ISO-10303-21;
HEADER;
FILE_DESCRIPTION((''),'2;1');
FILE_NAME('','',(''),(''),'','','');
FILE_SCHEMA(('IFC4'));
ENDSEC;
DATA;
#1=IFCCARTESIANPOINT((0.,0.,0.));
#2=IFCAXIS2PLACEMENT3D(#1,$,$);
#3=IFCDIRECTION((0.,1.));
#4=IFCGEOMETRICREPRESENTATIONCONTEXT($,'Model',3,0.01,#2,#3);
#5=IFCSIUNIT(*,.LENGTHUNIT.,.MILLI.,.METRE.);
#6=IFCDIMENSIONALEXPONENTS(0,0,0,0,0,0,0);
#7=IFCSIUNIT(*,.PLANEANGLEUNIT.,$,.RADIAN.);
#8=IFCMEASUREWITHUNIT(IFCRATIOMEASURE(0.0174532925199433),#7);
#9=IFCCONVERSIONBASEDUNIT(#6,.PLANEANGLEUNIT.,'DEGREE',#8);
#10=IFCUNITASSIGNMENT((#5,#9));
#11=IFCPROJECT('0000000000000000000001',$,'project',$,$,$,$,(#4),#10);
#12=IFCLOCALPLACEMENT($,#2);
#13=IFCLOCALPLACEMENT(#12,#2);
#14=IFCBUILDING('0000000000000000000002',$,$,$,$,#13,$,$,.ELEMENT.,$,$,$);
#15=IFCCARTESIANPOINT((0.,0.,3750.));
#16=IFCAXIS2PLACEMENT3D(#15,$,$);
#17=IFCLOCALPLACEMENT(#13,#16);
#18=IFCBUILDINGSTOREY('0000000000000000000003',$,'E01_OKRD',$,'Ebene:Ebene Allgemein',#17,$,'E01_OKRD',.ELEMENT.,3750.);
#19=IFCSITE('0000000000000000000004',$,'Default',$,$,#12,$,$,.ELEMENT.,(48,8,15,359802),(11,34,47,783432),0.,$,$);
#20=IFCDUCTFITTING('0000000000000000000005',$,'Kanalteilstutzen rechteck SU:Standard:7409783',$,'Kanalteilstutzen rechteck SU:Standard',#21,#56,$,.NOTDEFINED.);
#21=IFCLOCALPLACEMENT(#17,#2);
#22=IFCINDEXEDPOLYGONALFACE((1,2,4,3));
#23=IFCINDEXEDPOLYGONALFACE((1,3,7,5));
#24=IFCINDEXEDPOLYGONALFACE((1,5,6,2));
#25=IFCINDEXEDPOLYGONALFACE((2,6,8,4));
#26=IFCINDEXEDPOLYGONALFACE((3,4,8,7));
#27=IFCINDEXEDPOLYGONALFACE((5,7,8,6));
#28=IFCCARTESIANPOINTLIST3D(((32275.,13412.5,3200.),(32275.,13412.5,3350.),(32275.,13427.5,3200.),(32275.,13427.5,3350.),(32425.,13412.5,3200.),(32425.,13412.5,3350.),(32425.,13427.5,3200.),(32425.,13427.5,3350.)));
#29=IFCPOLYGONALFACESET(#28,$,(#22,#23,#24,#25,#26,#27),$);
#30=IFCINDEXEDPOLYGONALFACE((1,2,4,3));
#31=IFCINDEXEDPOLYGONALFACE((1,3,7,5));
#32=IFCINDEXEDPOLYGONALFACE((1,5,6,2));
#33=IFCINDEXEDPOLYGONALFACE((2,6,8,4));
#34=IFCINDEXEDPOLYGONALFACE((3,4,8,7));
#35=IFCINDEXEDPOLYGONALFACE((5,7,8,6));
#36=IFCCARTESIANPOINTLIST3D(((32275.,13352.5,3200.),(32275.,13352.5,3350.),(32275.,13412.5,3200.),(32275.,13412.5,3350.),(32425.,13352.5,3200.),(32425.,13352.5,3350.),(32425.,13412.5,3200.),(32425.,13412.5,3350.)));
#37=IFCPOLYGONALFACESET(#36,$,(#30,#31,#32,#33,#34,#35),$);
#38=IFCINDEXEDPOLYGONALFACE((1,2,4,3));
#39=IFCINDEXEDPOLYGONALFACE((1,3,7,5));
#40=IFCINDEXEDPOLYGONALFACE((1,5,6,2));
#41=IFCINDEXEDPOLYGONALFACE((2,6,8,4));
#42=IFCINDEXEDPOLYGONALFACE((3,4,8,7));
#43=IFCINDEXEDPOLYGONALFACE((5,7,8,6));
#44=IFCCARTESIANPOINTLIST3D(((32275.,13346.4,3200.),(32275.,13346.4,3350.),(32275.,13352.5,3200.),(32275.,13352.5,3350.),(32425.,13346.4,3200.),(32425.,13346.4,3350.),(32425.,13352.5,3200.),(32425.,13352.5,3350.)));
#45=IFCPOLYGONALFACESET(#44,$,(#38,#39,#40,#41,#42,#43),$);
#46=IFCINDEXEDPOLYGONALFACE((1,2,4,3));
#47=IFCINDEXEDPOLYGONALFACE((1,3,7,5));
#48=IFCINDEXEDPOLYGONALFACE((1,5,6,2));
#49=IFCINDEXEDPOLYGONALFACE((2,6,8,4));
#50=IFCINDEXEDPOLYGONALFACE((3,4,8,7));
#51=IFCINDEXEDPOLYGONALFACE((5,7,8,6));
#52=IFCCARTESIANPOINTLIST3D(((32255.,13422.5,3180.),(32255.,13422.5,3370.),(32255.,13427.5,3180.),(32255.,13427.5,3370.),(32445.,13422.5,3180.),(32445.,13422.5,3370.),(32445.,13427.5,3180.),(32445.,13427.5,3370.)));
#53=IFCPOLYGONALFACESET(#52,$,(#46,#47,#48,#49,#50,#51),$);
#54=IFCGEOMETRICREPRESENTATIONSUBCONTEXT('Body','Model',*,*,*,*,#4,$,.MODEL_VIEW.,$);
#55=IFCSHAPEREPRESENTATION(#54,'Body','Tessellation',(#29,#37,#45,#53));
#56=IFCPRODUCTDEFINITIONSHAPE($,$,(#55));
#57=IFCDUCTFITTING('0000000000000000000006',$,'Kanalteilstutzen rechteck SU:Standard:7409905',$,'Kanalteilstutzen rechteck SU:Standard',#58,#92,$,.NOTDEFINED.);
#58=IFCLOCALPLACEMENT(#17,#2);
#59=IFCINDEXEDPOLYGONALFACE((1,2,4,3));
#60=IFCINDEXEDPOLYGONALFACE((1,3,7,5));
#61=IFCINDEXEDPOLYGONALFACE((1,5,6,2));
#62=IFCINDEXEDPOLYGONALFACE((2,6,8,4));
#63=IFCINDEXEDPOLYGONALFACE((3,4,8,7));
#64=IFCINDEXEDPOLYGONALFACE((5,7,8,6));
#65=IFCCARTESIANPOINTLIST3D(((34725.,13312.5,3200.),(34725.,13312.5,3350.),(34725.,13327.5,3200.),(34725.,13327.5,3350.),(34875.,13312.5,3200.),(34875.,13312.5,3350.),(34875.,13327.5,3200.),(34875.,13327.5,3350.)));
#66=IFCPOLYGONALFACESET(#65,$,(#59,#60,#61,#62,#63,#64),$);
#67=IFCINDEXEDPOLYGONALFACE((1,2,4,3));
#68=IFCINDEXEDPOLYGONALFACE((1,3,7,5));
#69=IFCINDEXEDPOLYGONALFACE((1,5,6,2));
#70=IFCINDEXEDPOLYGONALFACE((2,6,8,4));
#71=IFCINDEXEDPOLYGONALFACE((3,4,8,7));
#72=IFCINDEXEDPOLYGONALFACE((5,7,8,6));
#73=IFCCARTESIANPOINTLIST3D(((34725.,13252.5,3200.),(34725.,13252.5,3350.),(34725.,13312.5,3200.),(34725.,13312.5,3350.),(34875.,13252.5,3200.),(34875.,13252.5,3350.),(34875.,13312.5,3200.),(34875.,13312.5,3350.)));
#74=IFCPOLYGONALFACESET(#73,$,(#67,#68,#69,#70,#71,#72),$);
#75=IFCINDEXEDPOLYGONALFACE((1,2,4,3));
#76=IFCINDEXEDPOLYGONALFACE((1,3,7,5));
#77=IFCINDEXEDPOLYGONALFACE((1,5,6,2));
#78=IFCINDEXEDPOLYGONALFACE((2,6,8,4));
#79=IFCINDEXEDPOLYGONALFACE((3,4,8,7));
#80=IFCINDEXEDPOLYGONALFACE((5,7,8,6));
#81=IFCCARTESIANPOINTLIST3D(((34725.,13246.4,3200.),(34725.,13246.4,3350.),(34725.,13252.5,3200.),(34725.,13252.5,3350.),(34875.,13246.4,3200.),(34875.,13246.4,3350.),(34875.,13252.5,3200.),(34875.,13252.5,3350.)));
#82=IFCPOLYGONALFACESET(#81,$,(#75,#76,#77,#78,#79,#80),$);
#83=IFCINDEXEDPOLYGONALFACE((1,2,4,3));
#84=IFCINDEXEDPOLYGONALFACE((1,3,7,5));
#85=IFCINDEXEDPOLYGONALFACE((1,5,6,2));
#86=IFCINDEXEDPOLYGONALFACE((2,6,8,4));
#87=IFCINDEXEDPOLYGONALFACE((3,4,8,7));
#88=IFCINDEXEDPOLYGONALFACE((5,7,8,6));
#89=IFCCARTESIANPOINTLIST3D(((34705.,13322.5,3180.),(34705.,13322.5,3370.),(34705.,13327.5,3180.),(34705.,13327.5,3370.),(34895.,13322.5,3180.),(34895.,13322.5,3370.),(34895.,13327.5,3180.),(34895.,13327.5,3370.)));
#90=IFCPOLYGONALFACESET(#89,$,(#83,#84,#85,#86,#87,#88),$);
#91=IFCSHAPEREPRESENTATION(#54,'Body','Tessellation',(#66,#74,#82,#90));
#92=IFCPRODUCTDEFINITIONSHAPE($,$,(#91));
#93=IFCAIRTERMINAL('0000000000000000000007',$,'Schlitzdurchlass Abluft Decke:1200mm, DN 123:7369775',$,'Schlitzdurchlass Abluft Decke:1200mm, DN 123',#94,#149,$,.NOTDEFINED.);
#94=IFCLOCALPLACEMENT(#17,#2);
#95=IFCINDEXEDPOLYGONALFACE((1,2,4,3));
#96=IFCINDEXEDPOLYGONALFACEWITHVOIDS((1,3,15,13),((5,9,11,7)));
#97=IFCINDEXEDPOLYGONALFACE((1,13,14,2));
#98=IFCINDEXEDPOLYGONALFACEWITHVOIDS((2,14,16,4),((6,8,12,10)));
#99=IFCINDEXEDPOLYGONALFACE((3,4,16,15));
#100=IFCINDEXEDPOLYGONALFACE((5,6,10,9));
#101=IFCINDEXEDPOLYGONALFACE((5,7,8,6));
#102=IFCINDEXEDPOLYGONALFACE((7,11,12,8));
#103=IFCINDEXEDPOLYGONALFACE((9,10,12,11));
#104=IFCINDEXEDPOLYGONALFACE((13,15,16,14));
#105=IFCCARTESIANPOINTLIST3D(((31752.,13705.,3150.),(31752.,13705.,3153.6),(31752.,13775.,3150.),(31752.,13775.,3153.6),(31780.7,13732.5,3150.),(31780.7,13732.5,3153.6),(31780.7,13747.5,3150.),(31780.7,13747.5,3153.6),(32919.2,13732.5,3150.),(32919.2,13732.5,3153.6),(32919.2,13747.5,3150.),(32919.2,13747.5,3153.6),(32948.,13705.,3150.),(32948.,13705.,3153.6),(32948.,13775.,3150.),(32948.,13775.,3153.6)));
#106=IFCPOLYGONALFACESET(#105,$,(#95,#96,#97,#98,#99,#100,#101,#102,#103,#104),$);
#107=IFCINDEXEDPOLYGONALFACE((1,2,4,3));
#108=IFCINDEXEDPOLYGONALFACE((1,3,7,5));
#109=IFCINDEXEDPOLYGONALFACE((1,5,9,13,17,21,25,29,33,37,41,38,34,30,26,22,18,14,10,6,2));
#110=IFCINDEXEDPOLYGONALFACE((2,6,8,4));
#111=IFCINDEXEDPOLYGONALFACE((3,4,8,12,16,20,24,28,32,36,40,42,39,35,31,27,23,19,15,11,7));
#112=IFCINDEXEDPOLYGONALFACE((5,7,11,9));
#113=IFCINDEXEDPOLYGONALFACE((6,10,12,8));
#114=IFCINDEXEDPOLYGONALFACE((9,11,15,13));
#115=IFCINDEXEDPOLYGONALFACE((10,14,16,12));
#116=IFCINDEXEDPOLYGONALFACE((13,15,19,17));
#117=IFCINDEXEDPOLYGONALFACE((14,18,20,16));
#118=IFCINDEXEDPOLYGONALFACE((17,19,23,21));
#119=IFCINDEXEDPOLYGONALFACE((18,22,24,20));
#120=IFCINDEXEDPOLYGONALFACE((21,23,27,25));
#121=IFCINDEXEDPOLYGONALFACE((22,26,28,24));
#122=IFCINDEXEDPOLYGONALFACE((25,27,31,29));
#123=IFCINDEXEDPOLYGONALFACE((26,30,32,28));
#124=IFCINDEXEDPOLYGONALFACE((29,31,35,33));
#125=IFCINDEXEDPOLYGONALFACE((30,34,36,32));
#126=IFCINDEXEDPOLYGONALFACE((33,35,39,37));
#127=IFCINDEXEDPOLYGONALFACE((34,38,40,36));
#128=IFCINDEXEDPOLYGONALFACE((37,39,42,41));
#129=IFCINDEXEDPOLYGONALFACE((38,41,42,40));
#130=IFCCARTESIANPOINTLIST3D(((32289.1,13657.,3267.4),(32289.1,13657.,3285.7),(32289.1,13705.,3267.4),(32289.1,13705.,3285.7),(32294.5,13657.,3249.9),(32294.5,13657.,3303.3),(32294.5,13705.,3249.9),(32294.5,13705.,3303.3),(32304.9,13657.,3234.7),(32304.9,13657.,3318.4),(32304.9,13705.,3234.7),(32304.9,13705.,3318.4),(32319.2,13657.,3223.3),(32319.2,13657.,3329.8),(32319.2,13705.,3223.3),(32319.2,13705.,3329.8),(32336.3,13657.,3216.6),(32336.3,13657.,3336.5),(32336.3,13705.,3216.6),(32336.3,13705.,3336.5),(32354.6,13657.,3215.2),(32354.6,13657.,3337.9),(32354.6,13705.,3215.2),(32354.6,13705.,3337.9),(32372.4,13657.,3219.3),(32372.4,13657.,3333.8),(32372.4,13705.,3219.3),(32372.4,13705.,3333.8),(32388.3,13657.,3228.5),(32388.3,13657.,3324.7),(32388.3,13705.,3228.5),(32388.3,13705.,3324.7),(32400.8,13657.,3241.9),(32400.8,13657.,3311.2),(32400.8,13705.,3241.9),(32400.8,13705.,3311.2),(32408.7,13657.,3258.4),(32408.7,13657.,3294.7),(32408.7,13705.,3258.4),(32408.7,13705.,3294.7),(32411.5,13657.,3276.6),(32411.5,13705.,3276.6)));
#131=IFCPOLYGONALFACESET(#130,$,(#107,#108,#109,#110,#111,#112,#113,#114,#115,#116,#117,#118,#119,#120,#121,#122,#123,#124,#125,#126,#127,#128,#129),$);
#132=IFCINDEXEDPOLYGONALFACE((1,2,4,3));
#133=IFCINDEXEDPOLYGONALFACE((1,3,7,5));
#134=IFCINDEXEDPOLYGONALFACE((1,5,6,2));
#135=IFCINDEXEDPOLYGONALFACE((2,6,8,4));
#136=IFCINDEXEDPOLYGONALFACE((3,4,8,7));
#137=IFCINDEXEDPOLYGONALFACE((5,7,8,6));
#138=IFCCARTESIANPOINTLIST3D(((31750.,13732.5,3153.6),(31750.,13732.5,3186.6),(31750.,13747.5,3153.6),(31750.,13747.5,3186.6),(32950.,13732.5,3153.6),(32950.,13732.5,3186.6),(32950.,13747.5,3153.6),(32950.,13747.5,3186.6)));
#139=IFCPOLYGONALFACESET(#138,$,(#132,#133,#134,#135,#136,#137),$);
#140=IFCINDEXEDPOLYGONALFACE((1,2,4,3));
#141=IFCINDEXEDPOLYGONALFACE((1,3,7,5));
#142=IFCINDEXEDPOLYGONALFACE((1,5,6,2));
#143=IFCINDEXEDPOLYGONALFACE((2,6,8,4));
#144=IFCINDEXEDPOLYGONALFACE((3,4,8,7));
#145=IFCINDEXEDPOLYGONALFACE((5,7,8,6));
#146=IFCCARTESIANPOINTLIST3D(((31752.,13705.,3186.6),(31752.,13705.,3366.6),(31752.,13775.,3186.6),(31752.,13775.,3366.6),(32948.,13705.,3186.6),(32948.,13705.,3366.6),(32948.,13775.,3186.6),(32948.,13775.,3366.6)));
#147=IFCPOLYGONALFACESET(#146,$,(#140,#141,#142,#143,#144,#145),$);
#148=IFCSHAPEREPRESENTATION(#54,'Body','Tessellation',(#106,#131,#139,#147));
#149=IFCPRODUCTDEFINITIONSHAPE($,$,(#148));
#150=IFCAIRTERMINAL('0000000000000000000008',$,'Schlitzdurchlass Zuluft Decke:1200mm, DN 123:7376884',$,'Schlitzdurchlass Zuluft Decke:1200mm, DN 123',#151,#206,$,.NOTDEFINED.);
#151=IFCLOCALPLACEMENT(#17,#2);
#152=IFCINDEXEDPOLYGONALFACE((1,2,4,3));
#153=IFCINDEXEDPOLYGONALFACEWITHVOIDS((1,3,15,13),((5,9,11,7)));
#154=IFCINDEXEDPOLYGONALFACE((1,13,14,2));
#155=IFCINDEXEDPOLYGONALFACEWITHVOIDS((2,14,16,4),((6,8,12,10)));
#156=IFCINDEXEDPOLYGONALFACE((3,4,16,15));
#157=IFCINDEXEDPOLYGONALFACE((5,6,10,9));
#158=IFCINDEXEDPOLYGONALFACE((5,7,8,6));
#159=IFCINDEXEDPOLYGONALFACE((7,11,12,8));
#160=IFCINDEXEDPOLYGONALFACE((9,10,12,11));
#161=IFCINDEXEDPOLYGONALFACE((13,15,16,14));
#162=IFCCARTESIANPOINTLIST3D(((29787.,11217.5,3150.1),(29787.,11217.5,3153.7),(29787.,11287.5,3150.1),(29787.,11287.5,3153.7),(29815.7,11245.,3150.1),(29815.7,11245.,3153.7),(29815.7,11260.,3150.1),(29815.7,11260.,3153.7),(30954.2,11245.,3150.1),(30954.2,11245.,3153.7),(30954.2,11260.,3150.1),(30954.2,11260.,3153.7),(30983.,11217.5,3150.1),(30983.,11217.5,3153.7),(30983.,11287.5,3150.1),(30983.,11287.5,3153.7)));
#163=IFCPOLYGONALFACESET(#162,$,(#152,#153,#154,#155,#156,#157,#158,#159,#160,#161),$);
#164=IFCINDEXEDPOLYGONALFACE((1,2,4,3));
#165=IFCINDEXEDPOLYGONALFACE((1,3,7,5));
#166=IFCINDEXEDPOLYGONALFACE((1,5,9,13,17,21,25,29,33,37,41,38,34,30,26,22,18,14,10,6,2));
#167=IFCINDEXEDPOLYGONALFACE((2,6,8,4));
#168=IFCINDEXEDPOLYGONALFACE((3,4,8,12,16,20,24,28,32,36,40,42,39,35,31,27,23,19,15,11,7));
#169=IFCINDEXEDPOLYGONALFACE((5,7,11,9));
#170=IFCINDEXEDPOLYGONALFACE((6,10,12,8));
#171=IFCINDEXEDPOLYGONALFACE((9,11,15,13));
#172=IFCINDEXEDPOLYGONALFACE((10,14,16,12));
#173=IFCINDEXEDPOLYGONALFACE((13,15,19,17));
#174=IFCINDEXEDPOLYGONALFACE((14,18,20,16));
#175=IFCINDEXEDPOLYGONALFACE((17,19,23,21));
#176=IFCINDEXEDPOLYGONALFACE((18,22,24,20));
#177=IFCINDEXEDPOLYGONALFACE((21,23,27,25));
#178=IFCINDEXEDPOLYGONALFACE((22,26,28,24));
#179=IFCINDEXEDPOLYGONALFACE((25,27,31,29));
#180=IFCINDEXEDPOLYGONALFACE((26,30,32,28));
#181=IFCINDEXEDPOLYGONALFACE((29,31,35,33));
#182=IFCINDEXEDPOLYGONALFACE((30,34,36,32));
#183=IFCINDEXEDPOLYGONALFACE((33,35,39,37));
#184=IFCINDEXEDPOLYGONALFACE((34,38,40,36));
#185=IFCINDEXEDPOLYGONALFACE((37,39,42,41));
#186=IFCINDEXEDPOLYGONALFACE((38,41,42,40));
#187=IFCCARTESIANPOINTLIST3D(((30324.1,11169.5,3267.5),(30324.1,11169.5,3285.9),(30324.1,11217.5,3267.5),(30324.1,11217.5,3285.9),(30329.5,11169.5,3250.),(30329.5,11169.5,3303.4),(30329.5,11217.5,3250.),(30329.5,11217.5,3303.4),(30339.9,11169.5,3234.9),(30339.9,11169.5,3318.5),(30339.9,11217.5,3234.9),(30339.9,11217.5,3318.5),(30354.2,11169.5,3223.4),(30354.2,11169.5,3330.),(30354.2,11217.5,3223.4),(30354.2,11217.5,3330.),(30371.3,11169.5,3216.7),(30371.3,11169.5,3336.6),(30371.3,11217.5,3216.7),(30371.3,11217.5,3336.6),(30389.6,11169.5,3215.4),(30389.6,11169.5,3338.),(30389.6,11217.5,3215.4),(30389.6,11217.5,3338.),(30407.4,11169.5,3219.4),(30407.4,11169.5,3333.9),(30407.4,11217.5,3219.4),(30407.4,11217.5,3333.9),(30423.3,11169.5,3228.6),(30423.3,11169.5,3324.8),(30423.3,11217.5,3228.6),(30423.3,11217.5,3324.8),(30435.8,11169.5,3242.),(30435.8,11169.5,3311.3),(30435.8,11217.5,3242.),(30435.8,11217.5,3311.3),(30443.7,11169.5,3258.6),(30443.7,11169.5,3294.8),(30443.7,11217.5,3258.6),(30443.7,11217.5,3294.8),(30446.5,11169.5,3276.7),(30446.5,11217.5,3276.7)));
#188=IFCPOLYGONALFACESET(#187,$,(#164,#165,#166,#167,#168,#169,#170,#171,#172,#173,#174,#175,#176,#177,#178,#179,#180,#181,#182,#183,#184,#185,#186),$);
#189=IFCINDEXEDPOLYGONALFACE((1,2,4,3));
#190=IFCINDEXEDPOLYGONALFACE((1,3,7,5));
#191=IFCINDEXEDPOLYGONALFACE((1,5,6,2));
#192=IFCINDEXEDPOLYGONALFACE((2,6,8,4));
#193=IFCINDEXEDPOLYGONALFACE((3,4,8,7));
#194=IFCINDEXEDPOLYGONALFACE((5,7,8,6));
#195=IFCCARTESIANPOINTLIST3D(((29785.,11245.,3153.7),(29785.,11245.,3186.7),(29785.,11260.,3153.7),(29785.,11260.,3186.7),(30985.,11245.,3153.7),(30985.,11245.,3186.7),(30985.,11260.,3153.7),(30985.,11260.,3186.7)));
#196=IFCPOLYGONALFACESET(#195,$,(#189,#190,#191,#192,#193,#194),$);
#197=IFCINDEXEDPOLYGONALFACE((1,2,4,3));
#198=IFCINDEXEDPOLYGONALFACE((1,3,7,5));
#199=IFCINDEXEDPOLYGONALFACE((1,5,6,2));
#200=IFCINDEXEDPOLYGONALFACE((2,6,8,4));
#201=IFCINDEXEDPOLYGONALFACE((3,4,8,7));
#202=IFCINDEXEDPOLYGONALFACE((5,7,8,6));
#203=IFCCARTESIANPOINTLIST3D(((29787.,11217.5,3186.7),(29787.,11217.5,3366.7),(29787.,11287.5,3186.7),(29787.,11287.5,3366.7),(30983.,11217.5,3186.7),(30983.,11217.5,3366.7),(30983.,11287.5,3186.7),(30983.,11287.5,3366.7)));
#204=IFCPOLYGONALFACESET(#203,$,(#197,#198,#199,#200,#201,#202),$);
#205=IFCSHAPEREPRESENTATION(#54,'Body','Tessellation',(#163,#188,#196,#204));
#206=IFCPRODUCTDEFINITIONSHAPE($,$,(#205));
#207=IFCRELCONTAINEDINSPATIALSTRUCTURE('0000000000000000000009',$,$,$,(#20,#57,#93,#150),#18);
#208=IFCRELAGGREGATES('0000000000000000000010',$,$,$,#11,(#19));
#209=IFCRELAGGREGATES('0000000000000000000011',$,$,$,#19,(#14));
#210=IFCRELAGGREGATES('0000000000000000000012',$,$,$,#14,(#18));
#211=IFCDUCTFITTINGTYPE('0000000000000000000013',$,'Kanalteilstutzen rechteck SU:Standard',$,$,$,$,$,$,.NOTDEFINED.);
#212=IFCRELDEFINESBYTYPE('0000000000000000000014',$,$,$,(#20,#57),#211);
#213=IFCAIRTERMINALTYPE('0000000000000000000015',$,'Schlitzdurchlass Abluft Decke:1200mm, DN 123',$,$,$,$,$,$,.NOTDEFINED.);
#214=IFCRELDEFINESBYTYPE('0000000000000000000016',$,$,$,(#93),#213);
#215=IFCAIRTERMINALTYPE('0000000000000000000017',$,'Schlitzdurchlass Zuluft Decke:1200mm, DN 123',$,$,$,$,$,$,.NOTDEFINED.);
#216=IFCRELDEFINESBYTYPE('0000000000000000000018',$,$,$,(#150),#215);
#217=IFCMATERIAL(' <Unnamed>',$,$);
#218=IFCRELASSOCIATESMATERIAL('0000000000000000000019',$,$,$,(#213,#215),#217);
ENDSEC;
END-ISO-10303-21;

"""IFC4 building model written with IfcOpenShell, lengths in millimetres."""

from ifc_helpers import new_model, entity, si_unit, converted_unit, direction, frame, frame_2d, origin, origin_2d_with_axis, place, context, subcontext, project, spatial, polyline, rectangle, circle, outline, extrude, source, transform, mapped, material, type_object, type_shapes, element, save


model = new_model("IFC4")

# Units and contexts
model_context = context("Model", 3, precision=0.01, world=origin(), true_north=direction((0.0, 1.0)))
body_context = subcontext(model_context, "Body", "Model", "MODEL_VIEW")
ifc_project = project(units=[si_unit("LENGTHUNIT", "METRE", prefix="MILLI"), converted_unit("PLANEANGLEUNIT", "DEGREE", entity("IfcRatioMeasure", 0.0174532925199433), si_unit("PLANEANGLEUNIT", "RADIAN"), dimensions=[0, 0, 0, 0, 0, 0, 0])], contexts=[model_context])

# Site, building, storey
site_placement = place(None, origin())
site = spatial("IfcSite", under=ifc_project, at=site_placement, Name="Default", CompositionType="ELEMENT", RefLatitude=(48, 8, 15, 359802), RefLongitude=(11, 34, 47, 783432), RefElevation=0.0)
building_placement = place(site_placement, origin())
building = spatial("IfcBuilding", under=site, at=building_placement, CompositionType="ELEMENT")
storey_placement = place(building_placement, frame((0.0, 0.0, 3750.0)))
storey = spatial("IfcBuildingStorey", under=building, at=storey_placement, Name="E01_OKRD", ObjectType="Ebene:Ebene Allgemein", LongName="E01_OKRD", CompositionType="ELEMENT", Elevation=3750.0)

# Duct fittings
duct_fitting_type_1 = type_object("IfcDuctFittingType", Name="Kanalteilstutzen rechteck SU:Standard", PredefinedType="NOTDEFINED")
shared_shape_1 = source(origin(), body_context, "Body", "SweptSolid", [
    extrude(rectangle(XDim=15.0, YDim=150.0, at=frame_2d((0.0, 0.0), x_axis=(1.0, 0.0))), frame((67.5, 0.0, -75.0)), (0.0, 0.0, 1.0), 150.0),
    extrude(rectangle(XDim=60.0, YDim=150.0, at=frame_2d((0.0, 0.0), x_axis=(1.0, 0.0))), frame((30.0, 0.0, -75.0)), (0.0, 0.0, 1.0), 150.0),
    extrude(rectangle(XDim=6.1, YDim=150.0, at=frame_2d((0.0, 0.0), x_axis=(1.0, 0.0))), frame((-3.0, 0.0, -75.0)), (0.0, 0.0, 1.0), 150.0),
    extrude(rectangle(XDim=5.0, YDim=190.0, at=origin_2d_with_axis()), frame((72.5, 0.0, -95.0)), (0.0, 0.0, 1.0), 190.0),
])
type_shapes(duct_fitting_type_1, [shared_shape_1])
for number, where, z_axis, x_axis, name in (
    (1, (32350.0, 13352.5, 3275.0), (0.0, 0.0, -1.0), (0.0, 1.0, 0.0), "Kanalteilstutzen rechteck SU:Standard:7409783"),
    (2, (34800.0, 13252.5, 3275.0), (0.0, 0.0, -1.0), (0.0, 1.0, 0.0), "Kanalteilstutzen rechteck SU:Standard:7409905"),
):
    element("IfcDuctFitting", number, at=place(storey_placement, frame(where, z_axis=z_axis, x_axis=x_axis)), inside=storey, type_object=duct_fitting_type_1, Name=name, ObjectType="Kanalteilstutzen rechteck SU:Standard", PredefinedType="NOTDEFINED", context=body_context, shape_type="MappedRepresentation", body=[
        mapped(shared_shape_1, transform((0.0, 0.0, 0.0), scale=1.0)),
    ])

# Air terminals
ifc_material_1 = material(Name=" <Unnamed>")
air_terminal_type_1 = type_object("IfcAirTerminalType", Name="Schlitzdurchlass Abluft Decke:1200mm, DN 123", PredefinedType="NOTDEFINED", material=ifc_material_1)
shared_shape_2 = source(origin(), body_context, "Body", "SweptSolid", [
    extrude(outline(polyline([(-598.0, -35.0), (598.0, -35.0), (598.0, 35.0), (-598.0, 35.0), (-598.0, -35.0)]), holes=[polyline([(-569.2, -7.5), (-569.2, 7.5), (569.2, 7.5), (569.2, -7.5), (-569.2, -7.5)])]), frame((0.0, 0.0, 0.0), z_axis=(0.0, 0.0, 1.0), x_axis=(-1.0, 0.0, 0.0)), (0.0, 0.0, 1.0), 3.6),
    extrude(circle(Radius=61.5, at=frame_2d((0.0, 0.0), x_axis=(1.0, 0.0))), frame((0.0, 35.0, 126.6), z_axis=(0.0, 1.0, 0.0), x_axis=(-1.0, 0.0, 0.0)), (0.0, 0.0, 1.0), 48.0),
    extrude(rectangle(XDim=1200.0, YDim=15.0, at=origin_2d_with_axis()), frame((0.0, 0.0, 3.6), z_axis=(0.0, 0.0, 1.0), x_axis=(-1.0, 0.0, 0.0)), (0.0, 0.0, 1.0), 33.0),
    extrude(rectangle(XDim=1196.0, YDim=70.0, at=origin_2d_with_axis()), frame((0.0, 0.0, 36.6), z_axis=(0.0, 0.0, 1.0), x_axis=(-1.0, 0.0, 0.0)), (0.0, 0.0, 1.0), 180.0),
])
type_shapes(air_terminal_type_1, [shared_shape_2])
air_terminal_1_placement = place(storey_placement, frame((32350.0, 13740.0, 3150.0), z_axis=(0.0, 0.0, 1.0), x_axis=(-1.0, 0.0, 0.0)))
element("IfcAirTerminal", 3, at=air_terminal_1_placement, inside=storey, type_object=air_terminal_type_1, Name="Schlitzdurchlass Abluft Decke:1200mm, DN 123:7369775", ObjectType="Schlitzdurchlass Abluft Decke:1200mm, DN 123", PredefinedType="NOTDEFINED", context=body_context, shape_type="MappedRepresentation", body=[
    mapped(shared_shape_2, transform((0.0, 0.0, 0.0), scale=1.0)),
])
air_terminal_type_2 = type_object("IfcAirTerminalType", Name="Schlitzdurchlass Zuluft Decke:1200mm, DN 123", PredefinedType="NOTDEFINED", material=ifc_material_1)
shared_shape_3 = source(origin(), body_context, "Body", "SweptSolid", [
    extrude(outline(polyline([(-598.0, -35.0), (598.0, -35.0), (598.0, 35.0), (-598.0, 35.0), (-598.0, -35.0)]), holes=[polyline([(-569.2, -7.5), (-569.2, 7.5), (569.2, 7.5), (569.2, -7.5), (-569.2, -7.5)])]), frame((600.0, 35.0, 0.0), z_axis=(0.0, 0.0, 1.0), x_axis=(-1.0, 0.0, 0.0)), (0.0, 0.0, 1.0), 3.6),
    extrude(circle(Radius=61.5, at=frame_2d((0.0, 0.0), x_axis=(1.0, 0.0))), frame((600.0, 70.0, 126.6), z_axis=(0.0, 1.0, 0.0), x_axis=(-1.0, 0.0, 0.0)), (0.0, 0.0, 1.0), 48.0),
    extrude(rectangle(XDim=1200.0, YDim=15.0, at=origin_2d_with_axis()), frame((600.0, 35.0, 3.6), z_axis=(0.0, 0.0, 1.0), x_axis=(-1.0, 0.0, 0.0)), (0.0, 0.0, 1.0), 33.0),
    extrude(rectangle(XDim=1196.0, YDim=70.0, at=origin_2d_with_axis()), frame((600.0, 35.0, 36.6), z_axis=(0.0, 0.0, 1.0), x_axis=(-1.0, 0.0, 0.0)), (0.0, 0.0, 1.0), 180.0),
])
type_shapes(air_terminal_type_2, [shared_shape_3])
air_terminal_2_placement = place(storey_placement, frame((30985.0, 11287.5, 3150.1), z_axis=(0.0, 0.0, 1.0), x_axis=(-1.0, 0.0, 0.0)))
element("IfcAirTerminal", 4, at=air_terminal_2_placement, inside=storey, type_object=air_terminal_type_2, Name="Schlitzdurchlass Zuluft Decke:1200mm, DN 123:7376884", ObjectType="Schlitzdurchlass Zuluft Decke:1200mm, DN 123", PredefinedType="NOTDEFINED", context=body_context, shape_type="MappedRepresentation", body=[
    mapped(shared_shape_3, transform((0.0, 0.0, 0.0), scale=1.0)),
])

save(model, "model.ifc")
